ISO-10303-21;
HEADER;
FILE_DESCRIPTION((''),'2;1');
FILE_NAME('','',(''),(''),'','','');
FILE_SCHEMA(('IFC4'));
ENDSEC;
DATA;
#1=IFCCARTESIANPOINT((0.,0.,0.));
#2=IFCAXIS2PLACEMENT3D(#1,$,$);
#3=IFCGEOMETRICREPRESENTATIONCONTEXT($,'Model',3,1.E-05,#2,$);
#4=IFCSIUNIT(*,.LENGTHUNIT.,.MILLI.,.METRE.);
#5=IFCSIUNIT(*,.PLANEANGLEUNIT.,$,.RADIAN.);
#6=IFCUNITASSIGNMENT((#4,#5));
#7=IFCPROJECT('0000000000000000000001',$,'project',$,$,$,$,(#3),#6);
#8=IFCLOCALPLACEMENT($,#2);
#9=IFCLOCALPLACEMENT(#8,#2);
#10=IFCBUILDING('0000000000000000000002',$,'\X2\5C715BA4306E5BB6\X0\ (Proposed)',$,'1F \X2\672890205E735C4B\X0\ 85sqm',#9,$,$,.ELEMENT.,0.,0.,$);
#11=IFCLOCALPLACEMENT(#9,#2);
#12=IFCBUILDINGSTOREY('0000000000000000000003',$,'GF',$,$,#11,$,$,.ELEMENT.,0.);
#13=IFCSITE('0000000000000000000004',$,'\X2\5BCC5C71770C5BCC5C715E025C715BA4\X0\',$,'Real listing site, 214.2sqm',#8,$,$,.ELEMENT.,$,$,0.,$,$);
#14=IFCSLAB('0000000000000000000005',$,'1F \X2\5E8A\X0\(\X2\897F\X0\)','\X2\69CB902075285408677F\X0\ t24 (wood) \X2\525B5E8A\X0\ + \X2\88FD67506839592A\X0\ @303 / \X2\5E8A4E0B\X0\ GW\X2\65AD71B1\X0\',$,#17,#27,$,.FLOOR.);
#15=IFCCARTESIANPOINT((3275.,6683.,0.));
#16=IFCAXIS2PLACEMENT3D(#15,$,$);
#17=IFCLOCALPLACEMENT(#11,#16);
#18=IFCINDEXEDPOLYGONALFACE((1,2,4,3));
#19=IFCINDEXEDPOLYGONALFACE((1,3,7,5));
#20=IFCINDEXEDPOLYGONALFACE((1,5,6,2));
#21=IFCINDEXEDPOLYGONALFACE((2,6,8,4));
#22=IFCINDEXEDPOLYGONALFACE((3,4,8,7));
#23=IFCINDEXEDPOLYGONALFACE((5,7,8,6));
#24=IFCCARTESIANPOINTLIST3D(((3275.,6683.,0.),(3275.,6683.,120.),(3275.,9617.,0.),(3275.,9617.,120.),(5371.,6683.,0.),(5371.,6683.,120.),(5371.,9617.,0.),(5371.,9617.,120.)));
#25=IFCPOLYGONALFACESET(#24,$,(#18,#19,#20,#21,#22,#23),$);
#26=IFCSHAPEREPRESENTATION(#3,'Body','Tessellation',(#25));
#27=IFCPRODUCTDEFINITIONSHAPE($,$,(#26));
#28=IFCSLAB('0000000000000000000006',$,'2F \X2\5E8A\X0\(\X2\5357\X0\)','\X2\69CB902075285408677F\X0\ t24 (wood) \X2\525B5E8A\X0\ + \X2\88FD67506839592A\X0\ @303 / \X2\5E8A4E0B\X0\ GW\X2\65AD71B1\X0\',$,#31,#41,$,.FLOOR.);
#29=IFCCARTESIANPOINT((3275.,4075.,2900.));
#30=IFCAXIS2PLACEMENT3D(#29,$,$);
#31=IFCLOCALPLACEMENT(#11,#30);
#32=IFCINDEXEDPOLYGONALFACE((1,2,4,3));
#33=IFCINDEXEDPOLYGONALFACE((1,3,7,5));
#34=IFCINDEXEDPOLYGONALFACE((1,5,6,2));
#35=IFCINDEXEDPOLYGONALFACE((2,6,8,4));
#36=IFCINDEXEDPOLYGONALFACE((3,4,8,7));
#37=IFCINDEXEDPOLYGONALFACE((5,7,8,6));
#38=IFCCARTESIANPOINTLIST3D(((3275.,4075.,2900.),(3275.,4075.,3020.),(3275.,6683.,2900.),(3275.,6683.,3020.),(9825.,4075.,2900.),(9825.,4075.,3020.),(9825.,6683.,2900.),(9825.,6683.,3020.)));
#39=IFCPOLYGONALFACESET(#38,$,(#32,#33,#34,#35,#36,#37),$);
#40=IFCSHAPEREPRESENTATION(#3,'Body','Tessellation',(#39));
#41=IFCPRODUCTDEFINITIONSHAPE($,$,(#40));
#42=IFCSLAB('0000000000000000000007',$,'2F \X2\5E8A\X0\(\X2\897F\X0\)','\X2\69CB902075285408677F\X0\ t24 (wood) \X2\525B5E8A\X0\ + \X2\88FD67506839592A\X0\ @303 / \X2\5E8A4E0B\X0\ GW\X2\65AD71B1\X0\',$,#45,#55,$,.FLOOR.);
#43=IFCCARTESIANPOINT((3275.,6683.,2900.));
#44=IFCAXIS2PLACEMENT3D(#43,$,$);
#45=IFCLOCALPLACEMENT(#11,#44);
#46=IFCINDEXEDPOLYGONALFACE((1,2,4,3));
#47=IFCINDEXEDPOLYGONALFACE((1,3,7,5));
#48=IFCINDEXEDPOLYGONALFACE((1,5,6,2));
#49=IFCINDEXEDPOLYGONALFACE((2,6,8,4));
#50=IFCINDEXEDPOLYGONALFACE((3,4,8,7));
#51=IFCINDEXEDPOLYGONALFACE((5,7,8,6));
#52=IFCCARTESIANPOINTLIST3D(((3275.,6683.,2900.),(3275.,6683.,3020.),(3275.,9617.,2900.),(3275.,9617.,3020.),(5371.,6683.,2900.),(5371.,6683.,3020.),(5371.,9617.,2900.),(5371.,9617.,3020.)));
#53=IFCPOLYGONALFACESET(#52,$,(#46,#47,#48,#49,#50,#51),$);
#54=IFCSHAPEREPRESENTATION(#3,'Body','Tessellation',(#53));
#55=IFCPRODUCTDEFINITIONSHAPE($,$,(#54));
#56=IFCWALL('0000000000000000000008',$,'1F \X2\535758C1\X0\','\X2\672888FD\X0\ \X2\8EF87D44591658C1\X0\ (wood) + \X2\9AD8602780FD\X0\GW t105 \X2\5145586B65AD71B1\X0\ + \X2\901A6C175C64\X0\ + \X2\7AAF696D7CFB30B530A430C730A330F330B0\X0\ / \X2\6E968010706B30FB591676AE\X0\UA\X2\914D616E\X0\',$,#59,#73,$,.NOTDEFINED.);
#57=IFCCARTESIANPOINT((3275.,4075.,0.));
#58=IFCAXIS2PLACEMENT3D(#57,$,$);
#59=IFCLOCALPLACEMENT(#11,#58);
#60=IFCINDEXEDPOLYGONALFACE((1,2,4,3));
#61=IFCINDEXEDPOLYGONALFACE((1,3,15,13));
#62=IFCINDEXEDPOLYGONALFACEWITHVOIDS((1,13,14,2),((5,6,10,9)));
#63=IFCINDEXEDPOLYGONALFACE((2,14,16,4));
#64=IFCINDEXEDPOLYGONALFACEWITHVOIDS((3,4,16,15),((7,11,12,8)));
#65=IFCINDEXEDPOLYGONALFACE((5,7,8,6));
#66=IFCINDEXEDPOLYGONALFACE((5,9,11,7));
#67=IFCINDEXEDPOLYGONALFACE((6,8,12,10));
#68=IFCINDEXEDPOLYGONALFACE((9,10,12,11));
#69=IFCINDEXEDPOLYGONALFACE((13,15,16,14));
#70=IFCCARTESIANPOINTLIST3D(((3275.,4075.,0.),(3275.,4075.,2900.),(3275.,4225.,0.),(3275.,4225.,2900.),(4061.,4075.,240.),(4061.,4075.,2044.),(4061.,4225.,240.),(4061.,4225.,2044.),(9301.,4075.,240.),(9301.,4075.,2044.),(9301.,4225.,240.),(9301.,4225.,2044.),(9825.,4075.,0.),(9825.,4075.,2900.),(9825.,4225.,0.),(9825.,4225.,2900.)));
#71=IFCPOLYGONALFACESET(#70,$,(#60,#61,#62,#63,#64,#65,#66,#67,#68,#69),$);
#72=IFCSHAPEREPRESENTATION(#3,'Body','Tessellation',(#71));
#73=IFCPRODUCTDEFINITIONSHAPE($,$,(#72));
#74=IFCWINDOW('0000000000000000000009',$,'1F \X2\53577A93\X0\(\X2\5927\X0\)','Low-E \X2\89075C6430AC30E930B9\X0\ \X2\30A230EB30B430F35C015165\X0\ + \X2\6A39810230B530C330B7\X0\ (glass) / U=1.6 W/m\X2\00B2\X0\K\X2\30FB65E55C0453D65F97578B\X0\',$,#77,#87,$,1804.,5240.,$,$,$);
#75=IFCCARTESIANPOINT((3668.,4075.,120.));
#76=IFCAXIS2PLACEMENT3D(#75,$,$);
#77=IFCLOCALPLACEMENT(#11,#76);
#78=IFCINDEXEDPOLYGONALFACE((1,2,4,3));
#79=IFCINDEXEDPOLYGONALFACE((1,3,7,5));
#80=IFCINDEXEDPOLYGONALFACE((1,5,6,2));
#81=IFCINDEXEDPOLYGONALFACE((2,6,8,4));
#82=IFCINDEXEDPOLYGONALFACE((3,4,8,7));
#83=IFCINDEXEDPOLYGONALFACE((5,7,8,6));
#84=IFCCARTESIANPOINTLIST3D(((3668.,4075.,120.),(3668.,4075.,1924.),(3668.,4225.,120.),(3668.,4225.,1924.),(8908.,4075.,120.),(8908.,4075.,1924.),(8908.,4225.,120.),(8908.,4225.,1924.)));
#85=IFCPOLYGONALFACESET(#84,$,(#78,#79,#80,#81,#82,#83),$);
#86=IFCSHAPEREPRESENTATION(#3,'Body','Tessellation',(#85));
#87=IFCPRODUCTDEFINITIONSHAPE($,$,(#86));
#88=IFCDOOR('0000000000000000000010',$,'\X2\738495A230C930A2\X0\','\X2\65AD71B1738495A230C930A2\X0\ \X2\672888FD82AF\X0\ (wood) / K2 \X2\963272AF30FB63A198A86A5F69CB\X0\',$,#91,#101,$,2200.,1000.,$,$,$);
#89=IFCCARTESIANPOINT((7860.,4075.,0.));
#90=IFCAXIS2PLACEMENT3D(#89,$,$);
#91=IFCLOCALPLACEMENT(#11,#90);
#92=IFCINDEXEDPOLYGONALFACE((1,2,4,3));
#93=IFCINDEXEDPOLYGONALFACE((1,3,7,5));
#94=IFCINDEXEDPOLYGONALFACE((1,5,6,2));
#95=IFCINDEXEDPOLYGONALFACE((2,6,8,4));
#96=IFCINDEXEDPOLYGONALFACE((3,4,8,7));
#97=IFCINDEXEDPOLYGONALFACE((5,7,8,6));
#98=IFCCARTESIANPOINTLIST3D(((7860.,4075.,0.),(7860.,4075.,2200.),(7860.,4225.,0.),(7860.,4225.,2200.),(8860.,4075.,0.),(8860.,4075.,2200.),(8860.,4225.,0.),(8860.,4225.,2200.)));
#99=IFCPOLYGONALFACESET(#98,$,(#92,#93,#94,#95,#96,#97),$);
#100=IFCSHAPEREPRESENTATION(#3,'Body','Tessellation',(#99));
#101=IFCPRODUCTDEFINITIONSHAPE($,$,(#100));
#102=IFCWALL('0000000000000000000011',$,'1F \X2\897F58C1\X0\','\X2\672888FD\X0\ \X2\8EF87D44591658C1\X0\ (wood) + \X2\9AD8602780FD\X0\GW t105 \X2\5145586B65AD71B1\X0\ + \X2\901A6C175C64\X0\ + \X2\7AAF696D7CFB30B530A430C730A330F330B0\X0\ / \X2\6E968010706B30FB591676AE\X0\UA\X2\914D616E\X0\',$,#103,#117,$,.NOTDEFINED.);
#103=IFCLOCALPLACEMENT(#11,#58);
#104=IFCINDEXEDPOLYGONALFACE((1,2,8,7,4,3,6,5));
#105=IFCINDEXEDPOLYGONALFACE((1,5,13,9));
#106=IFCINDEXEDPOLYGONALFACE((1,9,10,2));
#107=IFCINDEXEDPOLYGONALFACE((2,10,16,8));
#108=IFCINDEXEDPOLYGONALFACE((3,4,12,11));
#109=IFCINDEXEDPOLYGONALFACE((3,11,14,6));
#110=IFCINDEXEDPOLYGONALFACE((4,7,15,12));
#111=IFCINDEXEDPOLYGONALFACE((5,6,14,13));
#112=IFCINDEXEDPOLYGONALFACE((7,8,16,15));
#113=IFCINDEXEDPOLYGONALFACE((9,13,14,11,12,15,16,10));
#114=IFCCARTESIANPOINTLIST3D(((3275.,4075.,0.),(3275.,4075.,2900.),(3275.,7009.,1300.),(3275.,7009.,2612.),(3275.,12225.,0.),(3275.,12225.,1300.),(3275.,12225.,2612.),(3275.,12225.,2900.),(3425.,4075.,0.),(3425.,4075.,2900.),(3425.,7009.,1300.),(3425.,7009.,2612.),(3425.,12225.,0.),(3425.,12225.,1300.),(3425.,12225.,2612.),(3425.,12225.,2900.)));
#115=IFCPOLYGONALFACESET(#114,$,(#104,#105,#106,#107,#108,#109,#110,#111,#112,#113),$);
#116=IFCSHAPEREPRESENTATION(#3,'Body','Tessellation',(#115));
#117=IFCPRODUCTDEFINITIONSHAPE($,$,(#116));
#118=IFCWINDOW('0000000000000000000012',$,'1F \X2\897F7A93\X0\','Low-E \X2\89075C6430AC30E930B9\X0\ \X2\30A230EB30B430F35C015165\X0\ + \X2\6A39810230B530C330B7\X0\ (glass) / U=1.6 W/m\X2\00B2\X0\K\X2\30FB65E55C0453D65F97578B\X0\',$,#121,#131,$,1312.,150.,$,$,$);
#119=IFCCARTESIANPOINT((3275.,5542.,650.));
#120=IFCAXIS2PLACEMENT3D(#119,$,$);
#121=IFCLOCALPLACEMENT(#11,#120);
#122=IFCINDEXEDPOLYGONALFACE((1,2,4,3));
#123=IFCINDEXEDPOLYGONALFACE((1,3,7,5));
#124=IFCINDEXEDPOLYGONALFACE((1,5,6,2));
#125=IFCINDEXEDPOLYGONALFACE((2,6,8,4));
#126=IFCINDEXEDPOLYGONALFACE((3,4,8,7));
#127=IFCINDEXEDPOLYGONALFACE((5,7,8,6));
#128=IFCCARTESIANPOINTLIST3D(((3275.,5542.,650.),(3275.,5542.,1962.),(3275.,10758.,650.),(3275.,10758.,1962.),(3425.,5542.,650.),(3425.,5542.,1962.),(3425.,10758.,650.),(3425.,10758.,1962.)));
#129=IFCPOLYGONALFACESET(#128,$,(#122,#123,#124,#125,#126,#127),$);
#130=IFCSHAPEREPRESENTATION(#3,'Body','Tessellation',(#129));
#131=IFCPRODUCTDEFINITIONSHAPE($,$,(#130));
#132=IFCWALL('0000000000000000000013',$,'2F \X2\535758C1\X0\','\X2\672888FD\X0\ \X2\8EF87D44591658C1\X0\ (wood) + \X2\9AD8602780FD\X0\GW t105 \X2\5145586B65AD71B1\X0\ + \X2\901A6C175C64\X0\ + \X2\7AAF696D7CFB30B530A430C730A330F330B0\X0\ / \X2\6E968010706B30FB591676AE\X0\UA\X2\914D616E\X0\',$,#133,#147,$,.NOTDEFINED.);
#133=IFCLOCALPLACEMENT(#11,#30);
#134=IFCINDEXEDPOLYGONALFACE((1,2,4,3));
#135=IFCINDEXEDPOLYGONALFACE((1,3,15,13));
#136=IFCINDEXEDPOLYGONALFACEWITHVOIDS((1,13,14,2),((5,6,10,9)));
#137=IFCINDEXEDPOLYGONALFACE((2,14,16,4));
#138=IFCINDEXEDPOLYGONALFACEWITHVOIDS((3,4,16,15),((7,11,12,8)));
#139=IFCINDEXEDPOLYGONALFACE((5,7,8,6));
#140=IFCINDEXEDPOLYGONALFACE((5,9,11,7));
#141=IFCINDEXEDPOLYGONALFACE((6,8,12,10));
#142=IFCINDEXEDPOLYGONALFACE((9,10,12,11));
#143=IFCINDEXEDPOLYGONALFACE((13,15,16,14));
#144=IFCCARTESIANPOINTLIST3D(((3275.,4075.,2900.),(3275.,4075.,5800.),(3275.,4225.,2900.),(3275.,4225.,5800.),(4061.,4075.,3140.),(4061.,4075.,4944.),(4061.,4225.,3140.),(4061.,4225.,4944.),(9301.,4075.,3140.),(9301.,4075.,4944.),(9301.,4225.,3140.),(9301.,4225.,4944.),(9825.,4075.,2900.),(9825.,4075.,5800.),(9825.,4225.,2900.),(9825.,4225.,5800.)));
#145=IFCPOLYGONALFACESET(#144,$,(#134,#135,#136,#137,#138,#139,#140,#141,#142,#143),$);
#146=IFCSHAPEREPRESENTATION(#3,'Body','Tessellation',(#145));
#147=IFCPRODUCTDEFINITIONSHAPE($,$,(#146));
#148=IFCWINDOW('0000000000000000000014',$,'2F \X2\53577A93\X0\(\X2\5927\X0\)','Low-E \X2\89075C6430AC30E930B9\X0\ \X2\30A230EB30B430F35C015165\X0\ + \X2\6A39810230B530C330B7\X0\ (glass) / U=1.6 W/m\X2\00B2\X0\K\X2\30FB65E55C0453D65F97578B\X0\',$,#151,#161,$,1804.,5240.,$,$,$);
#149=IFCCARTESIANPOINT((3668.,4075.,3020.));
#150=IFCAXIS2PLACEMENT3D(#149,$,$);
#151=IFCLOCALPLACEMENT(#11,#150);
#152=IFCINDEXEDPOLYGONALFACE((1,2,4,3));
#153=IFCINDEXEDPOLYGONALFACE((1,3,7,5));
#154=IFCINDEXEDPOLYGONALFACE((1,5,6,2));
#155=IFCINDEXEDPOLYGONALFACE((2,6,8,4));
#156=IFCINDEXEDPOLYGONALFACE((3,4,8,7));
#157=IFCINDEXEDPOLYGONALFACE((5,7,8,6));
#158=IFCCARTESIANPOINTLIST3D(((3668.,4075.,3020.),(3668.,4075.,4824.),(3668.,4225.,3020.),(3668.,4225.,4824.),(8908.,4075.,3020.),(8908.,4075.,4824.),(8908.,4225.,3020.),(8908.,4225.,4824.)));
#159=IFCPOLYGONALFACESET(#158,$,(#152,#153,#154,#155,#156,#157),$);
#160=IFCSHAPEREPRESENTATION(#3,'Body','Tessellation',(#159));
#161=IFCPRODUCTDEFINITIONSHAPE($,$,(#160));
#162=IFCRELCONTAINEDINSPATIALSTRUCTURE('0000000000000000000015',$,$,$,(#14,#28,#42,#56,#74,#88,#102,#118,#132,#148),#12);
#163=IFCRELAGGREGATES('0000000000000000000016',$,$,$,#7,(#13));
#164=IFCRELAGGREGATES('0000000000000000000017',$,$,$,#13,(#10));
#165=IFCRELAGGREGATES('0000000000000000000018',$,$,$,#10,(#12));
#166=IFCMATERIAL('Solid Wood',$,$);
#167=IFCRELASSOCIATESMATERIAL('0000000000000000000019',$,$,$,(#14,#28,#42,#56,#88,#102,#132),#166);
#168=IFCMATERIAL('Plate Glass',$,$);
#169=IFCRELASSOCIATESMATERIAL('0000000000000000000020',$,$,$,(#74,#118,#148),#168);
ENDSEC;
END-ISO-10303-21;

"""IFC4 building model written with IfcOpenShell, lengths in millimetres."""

from ifc_helpers import new_model, si_unit, frame, frame_2d, origin, place, context, project, spatial, rectangle, extrude, material, element, fill, save


model = new_model("IFC4")

# Units and contexts
model_context = context("Model", 3, precision=1e-05, world=origin())
ifc_project = project(units=[si_unit("LENGTHUNIT", "METRE", prefix="MILLI"), si_unit("PLANEANGLEUNIT", "RADIAN")], contexts=[model_context])

# Site, building, storey
site_placement = place(None, origin())
site = spatial("IfcSite", under=ifc_project, at=site_placement, Name="富山県富山市山室", ObjectType="Real listing site, 214.2sqm", CompositionType="ELEMENT", RefElevation=0.0)
building_placement = place(site_placement, origin())
building = spatial("IfcBuilding", under=site, at=building_placement, Name="山室の家 (Proposed)", ObjectType="1F 木造平屋 85sqm", CompositionType="ELEMENT", ElevationOfRefHeight=0.0, ElevationOfTerrain=0.0)
storey_placement = place(building_placement, origin())
storey = spatial("IfcBuildingStorey", under=building, at=storey_placement, Name="GF", CompositionType="ELEMENT", Elevation=0.0)

# Slabs
ifc_material_1 = material(Name="Solid Wood")
slab_1_placement = place(storey_placement, frame((3275.0, 6683.0, 0.0)))
element("IfcSlab", 1, at=slab_1_placement, inside=storey, material=ifc_material_1, Name="1F 床(西)", Description="構造用合板 t24 (wood) 剛床 + 製材根太 @303 / 床下 GW断熱", PredefinedType="FLOOR", context=model_context, shape_type="SweptSolid", body=[
    extrude(rectangle(XDim=2096.0, YDim=2934.0, at=frame_2d((1048.0, 1467.0))), frame((3275.0, 6683.0, 0.0)), (0.0, 0.0, 1.0), 120.0),
])
slab_2_placement = place(storey_placement, frame((3275.0, 4075.0, 2900.0)))
element("IfcSlab", 2, at=slab_2_placement, inside=storey, material=ifc_material_1, Name="2F 床(南)", Description="構造用合板 t24 (wood) 剛床 + 製材根太 @303 / 床下 GW断熱", PredefinedType="FLOOR", context=model_context, shape_type="SweptSolid", body=[
    extrude(rectangle(XDim=6550.0, YDim=2608.0, at=frame_2d((3275.0, 1304.0))), frame((3275.0, 4075.0, 2900.0)), (0.0, 0.0, 1.0), 120.0),
])
slab_3_placement = place(storey_placement, frame((3275.0, 6683.0, 2900.0)))
element("IfcSlab", 3, at=slab_3_placement, inside=storey, material=ifc_material_1, Name="2F 床(西)", Description="構造用合板 t24 (wood) 剛床 + 製材根太 @303 / 床下 GW断熱", PredefinedType="FLOOR", context=model_context, shape_type="SweptSolid", body=[
    extrude(rectangle(XDim=2096.0, YDim=2934.0, at=frame_2d((1048.0, 1467.0))), frame((3275.0, 6683.0, 2900.0)), (0.0, 0.0, 1.0), 120.0),
])

# Wall, openings, window, door
wall_1_placement = place(storey_placement, frame((3275.0, 4075.0, 0.0)))
wall_1 = element("IfcWall", 4, at=wall_1_placement, inside=storey, material=ifc_material_1, Name="1F 南壁", Description="木製 軸組外壁 (wood) + 高性能GW t105 充填断熱 + 通気層 + 窯業系サイディング / 準耐火・外皮UA配慮", PredefinedType="NOTDEFINED", context=model_context, shape_type="SweptSolid", body=[
    extrude(rectangle(XDim=6550.0, YDim=150.0, at=frame_2d((3275.0, 75.0))), frame((3275.0, 4075.0, 0.0)), (0.0, 0.0, 1.0), 2900.0),
])
opening_1_placement = place(storey_placement, frame((3668.0, 4075.0, 120.0)))
opening_1 = element("IfcOpeningElement", 5, at=opening_1_placement, cuts=wall_1, PredefinedType="NOTDEFINED", context=model_context, shape_type="SweptSolid", body=[
    extrude(rectangle(XDim=5240.0, YDim=150.0, at=frame_2d((2620.0, 75.0))), frame((3668.0, 4075.0, 120.0)), (0.0, 0.0, 1.0), 1804.0),
])
opening_2_placement = place(storey_placement, frame((7860.0, 4075.0, 0.0)))
opening_2 = element("IfcOpeningElement", 6, at=opening_2_placement, cuts=wall_1, PredefinedType="NOTDEFINED", context=model_context, shape_type="SweptSolid", body=[
    extrude(rectangle(XDim=1000.0, YDim=150.0, at=frame_2d((500.0, 75.0))), frame((7860.0, 4075.0, 0.0)), (0.0, 0.0, 1.0), 2200.0),
])
ifc_material_2 = material(Name="Plate Glass")
window_1_placement = place(storey_placement, frame((3668.0, 4075.0, 120.0)))
window_1 = element("IfcWindow", 7, at=window_1_placement, inside=storey, material=ifc_material_2, Name="1F 南窓(大)", Description="Low-E 複層ガラス アルゴン封入 + 樹脂サッシ (glass) / U=1.6 W/m²K・日射取得型", OverallHeight=1804.0, OverallWidth=5240.0, context=model_context, shape_type="SweptSolid", body=[
    extrude(rectangle(XDim=5240.0, YDim=150.0, at=frame_2d((2620.0, 75.0))), frame((3668.0, 4075.0, 120.0)), (0.0, 0.0, 1.0), 1804.0),
])
fill(opening_1, window_1)
door_placement = place(storey_placement, frame((7860.0, 4075.0, 0.0)))
door = element("IfcDoor", 8, at=door_placement, inside=storey, material=ifc_material_1, Name="玄関ドア", Description="断熱玄関ドア 木製芯 (wood) / K2 防犯・採風機構", OverallHeight=2200.0, OverallWidth=1000.0, context=model_context, shape_type="SweptSolid", body=[
    extrude(rectangle(XDim=1000.0, YDim=150.0, at=frame_2d((500.0, 75.0))), frame((7860.0, 4075.0, 0.0)), (0.0, 0.0, 1.0), 2200.0),
])
fill(opening_2, door)

# Walls, openings, windows
wall_2_placement = place(storey_placement, frame((3275.0, 4075.0, 0.0)))
wall_2 = element("IfcWall", 9, at=wall_2_placement, inside=storey, material=ifc_material_1, Name="1F 西壁", Description="木製 軸組外壁 (wood) + 高性能GW t105 充填断熱 + 通気層 + 窯業系サイディング / 準耐火・外皮UA配慮", PredefinedType="NOTDEFINED", context=model_context, shape_type="SweptSolid", body=[
    extrude(rectangle(XDim=150.0, YDim=8150.0, at=frame_2d((75.0, 4075.0))), frame((3275.0, 4075.0, 0.0)), (0.0, 0.0, 1.0), 2900.0),
])
opening_3_placement = place(storey_placement, frame((3275.0, 5542.0, 650.0)))
opening_3 = element("IfcOpeningElement", 10, at=opening_3_placement, cuts=wall_2, PredefinedType="NOTDEFINED", context=model_context, shape_type="SweptSolid", body=[
    extrude(rectangle(XDim=150.0, YDim=5216.0, at=frame_2d((75.0, 2608.0))), frame((3275.0, 5542.0, 650.0)), (0.0, 0.0, 1.0), 1312.0),
])
window_2_placement = place(storey_placement, frame((3275.0, 5542.0, 650.0)))
window_2 = element("IfcWindow", 11, at=window_2_placement, inside=storey, material=ifc_material_2, Name="1F 西窓", Description="Low-E 複層ガラス アルゴン封入 + 樹脂サッシ (glass) / U=1.6 W/m²K・日射取得型", OverallHeight=1312.0, OverallWidth=150.0, context=model_context, shape_type="SweptSolid", body=[
    extrude(rectangle(XDim=150.0, YDim=5216.0, at=frame_2d((75.0, 2608.0))), frame((3275.0, 5542.0, 650.0)), (0.0, 0.0, 1.0), 1312.0),
])
fill(opening_3, window_2)
wall_3_placement = place(storey_placement, frame((3275.0, 4075.0, 2900.0)))
wall_3 = element("IfcWall", 12, at=wall_3_placement, inside=storey, material=ifc_material_1, Name="2F 南壁", Description="木製 軸組外壁 (wood) + 高性能GW t105 充填断熱 + 通気層 + 窯業系サイディング / 準耐火・外皮UA配慮", PredefinedType="NOTDEFINED", context=model_context, shape_type="SweptSolid", body=[
    extrude(rectangle(XDim=6550.0, YDim=150.0, at=frame_2d((3275.0, 75.0))), frame((3275.0, 4075.0, 2900.0)), (0.0, 0.0, 1.0), 2900.0),
])
opening_4_placement = place(storey_placement, frame((3668.0, 4075.0, 3020.0)))
opening_4 = element("IfcOpeningElement", 13, at=opening_4_placement, cuts=wall_3, PredefinedType="NOTDEFINED", context=model_context, shape_type="SweptSolid", body=[
    extrude(rectangle(XDim=5240.0, YDim=150.0, at=frame_2d((2620.0, 75.0))), frame((3668.0, 4075.0, 3020.0)), (0.0, 0.0, 1.0), 1804.0),
])
window_3_placement = place(storey_placement, frame((3668.0, 4075.0, 3020.0)))
window_3 = element("IfcWindow", 14, at=window_3_placement, inside=storey, material=ifc_material_2, Name="2F 南窓(大)", Description="Low-E 複層ガラス アルゴン封入 + 樹脂サッシ (glass) / U=1.6 W/m²K・日射取得型", OverallHeight=1804.0, OverallWidth=5240.0, context=model_context, shape_type="SweptSolid", body=[
    extrude(rectangle(XDim=5240.0, YDim=150.0, at=frame_2d((2620.0, 75.0))), frame((3668.0, 4075.0, 3020.0)), (0.0, 0.0, 1.0), 1804.0),
])
fill(opening_4, window_3)

save(model, "model.ifc")
